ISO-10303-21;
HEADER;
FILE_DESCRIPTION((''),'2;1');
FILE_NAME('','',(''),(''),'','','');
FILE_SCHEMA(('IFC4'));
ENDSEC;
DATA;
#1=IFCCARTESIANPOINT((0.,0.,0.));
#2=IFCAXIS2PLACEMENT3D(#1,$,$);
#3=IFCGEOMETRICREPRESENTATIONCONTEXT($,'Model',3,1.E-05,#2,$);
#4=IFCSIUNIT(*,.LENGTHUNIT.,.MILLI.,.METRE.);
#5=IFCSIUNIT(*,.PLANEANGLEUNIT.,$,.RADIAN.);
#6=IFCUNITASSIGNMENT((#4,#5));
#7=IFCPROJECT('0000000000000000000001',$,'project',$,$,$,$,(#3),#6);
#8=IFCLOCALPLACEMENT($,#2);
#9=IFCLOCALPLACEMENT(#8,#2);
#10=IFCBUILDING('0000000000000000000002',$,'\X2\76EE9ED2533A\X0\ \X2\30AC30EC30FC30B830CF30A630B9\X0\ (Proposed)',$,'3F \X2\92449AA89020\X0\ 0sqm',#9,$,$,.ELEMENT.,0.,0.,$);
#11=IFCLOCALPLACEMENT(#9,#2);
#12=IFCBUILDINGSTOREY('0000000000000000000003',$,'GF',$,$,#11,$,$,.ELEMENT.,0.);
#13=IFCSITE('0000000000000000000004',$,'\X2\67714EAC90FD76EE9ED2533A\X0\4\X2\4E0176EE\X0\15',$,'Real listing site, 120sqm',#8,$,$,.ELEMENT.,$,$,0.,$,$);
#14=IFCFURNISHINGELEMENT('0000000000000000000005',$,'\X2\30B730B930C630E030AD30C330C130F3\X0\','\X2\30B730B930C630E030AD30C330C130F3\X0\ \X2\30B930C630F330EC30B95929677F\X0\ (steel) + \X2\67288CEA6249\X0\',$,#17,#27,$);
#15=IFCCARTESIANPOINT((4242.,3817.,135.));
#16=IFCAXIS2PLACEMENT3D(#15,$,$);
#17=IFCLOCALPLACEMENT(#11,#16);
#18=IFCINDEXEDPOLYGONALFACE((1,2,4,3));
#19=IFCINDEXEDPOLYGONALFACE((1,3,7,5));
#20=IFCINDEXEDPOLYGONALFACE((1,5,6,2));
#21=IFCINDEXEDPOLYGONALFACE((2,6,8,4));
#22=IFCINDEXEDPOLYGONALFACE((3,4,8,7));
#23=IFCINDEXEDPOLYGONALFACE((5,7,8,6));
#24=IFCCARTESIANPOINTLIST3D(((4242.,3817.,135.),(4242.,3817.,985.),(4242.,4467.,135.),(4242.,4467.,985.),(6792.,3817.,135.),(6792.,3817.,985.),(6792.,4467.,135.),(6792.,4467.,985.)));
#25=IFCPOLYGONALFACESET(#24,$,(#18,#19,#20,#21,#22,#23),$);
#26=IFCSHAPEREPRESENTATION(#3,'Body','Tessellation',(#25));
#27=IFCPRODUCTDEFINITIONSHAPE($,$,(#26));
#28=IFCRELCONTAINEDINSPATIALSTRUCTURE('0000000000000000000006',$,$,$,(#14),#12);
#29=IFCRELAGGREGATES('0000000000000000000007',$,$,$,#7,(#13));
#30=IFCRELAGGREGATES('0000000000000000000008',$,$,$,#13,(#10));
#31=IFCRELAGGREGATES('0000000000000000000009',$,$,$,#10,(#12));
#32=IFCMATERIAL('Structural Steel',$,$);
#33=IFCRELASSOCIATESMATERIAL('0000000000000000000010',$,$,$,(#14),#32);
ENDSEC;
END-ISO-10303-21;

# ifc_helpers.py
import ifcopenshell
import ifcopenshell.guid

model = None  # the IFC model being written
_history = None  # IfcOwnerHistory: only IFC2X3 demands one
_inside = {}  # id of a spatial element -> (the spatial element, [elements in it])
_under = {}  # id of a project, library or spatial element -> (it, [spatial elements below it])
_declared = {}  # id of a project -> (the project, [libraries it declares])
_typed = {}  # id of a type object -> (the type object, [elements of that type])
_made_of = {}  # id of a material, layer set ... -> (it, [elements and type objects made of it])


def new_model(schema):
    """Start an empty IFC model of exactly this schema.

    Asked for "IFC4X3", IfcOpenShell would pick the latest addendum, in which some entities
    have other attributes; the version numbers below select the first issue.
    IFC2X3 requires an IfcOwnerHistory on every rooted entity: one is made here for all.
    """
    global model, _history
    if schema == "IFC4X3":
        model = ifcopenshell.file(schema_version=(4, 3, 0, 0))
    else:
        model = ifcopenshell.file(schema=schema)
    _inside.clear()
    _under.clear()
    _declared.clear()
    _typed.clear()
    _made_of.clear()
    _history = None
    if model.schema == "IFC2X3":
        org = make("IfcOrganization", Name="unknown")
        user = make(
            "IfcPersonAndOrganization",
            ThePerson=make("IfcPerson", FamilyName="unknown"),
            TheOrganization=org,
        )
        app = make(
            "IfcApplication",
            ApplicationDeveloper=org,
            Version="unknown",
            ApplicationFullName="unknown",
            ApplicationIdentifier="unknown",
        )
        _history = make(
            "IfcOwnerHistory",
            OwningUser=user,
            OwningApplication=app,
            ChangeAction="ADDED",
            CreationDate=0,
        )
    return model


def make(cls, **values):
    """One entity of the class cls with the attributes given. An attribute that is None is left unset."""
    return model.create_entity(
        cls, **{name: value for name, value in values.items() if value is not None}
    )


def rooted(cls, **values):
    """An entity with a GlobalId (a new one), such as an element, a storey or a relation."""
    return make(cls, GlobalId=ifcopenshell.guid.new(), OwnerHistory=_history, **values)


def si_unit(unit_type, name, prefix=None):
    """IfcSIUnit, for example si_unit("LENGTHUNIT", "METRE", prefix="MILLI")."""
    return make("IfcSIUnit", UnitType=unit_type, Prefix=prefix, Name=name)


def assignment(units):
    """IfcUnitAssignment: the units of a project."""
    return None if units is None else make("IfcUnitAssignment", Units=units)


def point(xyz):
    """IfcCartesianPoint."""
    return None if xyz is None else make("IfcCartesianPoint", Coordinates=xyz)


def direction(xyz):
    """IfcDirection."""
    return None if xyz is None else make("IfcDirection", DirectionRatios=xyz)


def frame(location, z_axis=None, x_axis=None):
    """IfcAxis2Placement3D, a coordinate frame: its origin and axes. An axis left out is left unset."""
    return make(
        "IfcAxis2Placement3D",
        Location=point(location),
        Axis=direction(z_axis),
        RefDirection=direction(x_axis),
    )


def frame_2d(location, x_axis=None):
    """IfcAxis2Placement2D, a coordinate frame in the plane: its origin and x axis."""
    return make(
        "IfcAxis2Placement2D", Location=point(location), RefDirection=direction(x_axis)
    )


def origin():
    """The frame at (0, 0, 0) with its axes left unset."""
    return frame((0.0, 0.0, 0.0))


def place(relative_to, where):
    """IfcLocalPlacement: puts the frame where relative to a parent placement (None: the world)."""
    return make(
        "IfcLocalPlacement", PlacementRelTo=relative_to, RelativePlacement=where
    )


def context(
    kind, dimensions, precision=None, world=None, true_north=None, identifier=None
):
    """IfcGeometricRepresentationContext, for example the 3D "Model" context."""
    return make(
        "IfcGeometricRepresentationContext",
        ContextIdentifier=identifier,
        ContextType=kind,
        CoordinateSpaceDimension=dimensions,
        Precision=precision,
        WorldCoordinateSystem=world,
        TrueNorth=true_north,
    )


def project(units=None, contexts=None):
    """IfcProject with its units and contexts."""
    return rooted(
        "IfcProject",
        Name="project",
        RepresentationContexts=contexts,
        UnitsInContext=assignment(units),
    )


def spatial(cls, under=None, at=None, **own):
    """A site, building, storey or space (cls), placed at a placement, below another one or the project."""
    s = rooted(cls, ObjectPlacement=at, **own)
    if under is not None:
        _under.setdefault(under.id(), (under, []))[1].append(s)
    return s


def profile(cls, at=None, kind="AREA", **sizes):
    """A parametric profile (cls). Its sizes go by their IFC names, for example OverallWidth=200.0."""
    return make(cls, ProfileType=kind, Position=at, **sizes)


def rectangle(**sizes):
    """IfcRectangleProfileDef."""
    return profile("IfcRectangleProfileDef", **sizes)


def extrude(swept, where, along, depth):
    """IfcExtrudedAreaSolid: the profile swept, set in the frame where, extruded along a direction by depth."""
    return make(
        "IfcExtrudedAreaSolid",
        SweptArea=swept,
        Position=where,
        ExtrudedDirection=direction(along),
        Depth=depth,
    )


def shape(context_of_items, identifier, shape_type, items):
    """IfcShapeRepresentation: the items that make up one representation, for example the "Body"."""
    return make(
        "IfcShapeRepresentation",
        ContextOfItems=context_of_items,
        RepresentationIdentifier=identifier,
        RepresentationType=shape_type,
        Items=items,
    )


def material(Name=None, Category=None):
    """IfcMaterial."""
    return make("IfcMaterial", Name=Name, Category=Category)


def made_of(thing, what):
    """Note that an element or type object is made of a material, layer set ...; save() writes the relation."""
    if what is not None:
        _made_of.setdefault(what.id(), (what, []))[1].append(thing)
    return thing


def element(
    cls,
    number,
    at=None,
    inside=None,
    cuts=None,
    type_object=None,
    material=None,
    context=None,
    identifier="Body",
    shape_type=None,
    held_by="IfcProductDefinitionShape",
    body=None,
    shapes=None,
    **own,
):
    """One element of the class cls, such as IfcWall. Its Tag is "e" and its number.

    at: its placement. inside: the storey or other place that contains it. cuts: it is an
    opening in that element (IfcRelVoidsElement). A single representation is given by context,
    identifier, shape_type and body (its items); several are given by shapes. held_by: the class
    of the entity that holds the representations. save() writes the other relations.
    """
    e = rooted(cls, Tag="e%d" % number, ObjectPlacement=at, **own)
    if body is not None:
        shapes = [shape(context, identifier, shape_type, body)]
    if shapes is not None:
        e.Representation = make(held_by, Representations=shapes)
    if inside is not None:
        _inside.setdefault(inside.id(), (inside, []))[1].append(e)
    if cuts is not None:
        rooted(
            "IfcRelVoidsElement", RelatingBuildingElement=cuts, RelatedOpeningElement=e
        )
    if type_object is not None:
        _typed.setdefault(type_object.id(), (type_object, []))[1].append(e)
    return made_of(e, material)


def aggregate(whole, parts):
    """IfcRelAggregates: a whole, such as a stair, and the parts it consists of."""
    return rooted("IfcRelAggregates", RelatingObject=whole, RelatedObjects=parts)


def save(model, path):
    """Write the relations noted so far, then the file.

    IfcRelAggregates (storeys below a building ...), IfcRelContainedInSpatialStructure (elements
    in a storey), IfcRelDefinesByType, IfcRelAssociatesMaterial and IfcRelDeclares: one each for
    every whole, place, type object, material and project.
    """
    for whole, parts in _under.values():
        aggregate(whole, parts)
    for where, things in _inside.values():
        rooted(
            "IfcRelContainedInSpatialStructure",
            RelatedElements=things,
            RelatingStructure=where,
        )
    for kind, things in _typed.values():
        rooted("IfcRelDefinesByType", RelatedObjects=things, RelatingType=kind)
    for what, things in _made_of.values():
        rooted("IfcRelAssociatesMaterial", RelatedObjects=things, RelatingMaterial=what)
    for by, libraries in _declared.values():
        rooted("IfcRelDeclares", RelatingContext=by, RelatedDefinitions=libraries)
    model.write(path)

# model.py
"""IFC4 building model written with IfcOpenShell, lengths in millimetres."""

from ifc_helpers import new_model, si_unit, frame, frame_2d, origin, place, context, project, spatial, rectangle, extrude, material, element, save


model = new_model("IFC4")

# Units and contexts
model_context = context("Model", 3, precision=1e-05, world=origin())
ifc_project = project(units=[si_unit("LENGTHUNIT", "METRE", prefix="MILLI"), si_unit("PLANEANGLEUNIT", "RADIAN")], contexts=[model_context])

# Site, building, storey
site_placement = place(None, origin())
site = spatial("IfcSite", under=ifc_project, at=site_placement, Name="東京都目黒区4丁目15", ObjectType="Real listing site, 120sqm", CompositionType="ELEMENT", RefElevation=0.0)
building_placement = place(site_placement, origin())
building = spatial("IfcBuilding", under=site, at=building_placement, Name="目黒区 ガレージハウス (Proposed)", ObjectType="3F 鉄骨造 0sqm", CompositionType="ELEMENT", ElevationOfRefHeight=0.0, ElevationOfTerrain=0.0)
storey_placement = place(building_placement, origin())
storey = spatial("IfcBuildingStorey", under=building, at=storey_placement, Name="GF", CompositionType="ELEMENT", Elevation=0.0)

# Furnishing element
ifc_material_1 = material(Name="Structural Steel")
furnishing_1_placement = place(storey_placement, frame((4242.0, 3817.0, 135.0)))
element("IfcFurnishingElement", 1, at=furnishing_1_placement, inside=storey, material=ifc_material_1, Name="システムキッチン", Description="システムキッチン ステンレス天板 (steel) + 木質扉", context=model_context, shape_type="SweptSolid", body=[
    extrude(rectangle(XDim=2550.0, YDim=650.0, at=frame_2d((1275.0, 325.0))), frame((4242.0, 3817.0, 135.0)), (0.0, 0.0, 1.0), 850.0),
])

save(model, "model.ifc")
